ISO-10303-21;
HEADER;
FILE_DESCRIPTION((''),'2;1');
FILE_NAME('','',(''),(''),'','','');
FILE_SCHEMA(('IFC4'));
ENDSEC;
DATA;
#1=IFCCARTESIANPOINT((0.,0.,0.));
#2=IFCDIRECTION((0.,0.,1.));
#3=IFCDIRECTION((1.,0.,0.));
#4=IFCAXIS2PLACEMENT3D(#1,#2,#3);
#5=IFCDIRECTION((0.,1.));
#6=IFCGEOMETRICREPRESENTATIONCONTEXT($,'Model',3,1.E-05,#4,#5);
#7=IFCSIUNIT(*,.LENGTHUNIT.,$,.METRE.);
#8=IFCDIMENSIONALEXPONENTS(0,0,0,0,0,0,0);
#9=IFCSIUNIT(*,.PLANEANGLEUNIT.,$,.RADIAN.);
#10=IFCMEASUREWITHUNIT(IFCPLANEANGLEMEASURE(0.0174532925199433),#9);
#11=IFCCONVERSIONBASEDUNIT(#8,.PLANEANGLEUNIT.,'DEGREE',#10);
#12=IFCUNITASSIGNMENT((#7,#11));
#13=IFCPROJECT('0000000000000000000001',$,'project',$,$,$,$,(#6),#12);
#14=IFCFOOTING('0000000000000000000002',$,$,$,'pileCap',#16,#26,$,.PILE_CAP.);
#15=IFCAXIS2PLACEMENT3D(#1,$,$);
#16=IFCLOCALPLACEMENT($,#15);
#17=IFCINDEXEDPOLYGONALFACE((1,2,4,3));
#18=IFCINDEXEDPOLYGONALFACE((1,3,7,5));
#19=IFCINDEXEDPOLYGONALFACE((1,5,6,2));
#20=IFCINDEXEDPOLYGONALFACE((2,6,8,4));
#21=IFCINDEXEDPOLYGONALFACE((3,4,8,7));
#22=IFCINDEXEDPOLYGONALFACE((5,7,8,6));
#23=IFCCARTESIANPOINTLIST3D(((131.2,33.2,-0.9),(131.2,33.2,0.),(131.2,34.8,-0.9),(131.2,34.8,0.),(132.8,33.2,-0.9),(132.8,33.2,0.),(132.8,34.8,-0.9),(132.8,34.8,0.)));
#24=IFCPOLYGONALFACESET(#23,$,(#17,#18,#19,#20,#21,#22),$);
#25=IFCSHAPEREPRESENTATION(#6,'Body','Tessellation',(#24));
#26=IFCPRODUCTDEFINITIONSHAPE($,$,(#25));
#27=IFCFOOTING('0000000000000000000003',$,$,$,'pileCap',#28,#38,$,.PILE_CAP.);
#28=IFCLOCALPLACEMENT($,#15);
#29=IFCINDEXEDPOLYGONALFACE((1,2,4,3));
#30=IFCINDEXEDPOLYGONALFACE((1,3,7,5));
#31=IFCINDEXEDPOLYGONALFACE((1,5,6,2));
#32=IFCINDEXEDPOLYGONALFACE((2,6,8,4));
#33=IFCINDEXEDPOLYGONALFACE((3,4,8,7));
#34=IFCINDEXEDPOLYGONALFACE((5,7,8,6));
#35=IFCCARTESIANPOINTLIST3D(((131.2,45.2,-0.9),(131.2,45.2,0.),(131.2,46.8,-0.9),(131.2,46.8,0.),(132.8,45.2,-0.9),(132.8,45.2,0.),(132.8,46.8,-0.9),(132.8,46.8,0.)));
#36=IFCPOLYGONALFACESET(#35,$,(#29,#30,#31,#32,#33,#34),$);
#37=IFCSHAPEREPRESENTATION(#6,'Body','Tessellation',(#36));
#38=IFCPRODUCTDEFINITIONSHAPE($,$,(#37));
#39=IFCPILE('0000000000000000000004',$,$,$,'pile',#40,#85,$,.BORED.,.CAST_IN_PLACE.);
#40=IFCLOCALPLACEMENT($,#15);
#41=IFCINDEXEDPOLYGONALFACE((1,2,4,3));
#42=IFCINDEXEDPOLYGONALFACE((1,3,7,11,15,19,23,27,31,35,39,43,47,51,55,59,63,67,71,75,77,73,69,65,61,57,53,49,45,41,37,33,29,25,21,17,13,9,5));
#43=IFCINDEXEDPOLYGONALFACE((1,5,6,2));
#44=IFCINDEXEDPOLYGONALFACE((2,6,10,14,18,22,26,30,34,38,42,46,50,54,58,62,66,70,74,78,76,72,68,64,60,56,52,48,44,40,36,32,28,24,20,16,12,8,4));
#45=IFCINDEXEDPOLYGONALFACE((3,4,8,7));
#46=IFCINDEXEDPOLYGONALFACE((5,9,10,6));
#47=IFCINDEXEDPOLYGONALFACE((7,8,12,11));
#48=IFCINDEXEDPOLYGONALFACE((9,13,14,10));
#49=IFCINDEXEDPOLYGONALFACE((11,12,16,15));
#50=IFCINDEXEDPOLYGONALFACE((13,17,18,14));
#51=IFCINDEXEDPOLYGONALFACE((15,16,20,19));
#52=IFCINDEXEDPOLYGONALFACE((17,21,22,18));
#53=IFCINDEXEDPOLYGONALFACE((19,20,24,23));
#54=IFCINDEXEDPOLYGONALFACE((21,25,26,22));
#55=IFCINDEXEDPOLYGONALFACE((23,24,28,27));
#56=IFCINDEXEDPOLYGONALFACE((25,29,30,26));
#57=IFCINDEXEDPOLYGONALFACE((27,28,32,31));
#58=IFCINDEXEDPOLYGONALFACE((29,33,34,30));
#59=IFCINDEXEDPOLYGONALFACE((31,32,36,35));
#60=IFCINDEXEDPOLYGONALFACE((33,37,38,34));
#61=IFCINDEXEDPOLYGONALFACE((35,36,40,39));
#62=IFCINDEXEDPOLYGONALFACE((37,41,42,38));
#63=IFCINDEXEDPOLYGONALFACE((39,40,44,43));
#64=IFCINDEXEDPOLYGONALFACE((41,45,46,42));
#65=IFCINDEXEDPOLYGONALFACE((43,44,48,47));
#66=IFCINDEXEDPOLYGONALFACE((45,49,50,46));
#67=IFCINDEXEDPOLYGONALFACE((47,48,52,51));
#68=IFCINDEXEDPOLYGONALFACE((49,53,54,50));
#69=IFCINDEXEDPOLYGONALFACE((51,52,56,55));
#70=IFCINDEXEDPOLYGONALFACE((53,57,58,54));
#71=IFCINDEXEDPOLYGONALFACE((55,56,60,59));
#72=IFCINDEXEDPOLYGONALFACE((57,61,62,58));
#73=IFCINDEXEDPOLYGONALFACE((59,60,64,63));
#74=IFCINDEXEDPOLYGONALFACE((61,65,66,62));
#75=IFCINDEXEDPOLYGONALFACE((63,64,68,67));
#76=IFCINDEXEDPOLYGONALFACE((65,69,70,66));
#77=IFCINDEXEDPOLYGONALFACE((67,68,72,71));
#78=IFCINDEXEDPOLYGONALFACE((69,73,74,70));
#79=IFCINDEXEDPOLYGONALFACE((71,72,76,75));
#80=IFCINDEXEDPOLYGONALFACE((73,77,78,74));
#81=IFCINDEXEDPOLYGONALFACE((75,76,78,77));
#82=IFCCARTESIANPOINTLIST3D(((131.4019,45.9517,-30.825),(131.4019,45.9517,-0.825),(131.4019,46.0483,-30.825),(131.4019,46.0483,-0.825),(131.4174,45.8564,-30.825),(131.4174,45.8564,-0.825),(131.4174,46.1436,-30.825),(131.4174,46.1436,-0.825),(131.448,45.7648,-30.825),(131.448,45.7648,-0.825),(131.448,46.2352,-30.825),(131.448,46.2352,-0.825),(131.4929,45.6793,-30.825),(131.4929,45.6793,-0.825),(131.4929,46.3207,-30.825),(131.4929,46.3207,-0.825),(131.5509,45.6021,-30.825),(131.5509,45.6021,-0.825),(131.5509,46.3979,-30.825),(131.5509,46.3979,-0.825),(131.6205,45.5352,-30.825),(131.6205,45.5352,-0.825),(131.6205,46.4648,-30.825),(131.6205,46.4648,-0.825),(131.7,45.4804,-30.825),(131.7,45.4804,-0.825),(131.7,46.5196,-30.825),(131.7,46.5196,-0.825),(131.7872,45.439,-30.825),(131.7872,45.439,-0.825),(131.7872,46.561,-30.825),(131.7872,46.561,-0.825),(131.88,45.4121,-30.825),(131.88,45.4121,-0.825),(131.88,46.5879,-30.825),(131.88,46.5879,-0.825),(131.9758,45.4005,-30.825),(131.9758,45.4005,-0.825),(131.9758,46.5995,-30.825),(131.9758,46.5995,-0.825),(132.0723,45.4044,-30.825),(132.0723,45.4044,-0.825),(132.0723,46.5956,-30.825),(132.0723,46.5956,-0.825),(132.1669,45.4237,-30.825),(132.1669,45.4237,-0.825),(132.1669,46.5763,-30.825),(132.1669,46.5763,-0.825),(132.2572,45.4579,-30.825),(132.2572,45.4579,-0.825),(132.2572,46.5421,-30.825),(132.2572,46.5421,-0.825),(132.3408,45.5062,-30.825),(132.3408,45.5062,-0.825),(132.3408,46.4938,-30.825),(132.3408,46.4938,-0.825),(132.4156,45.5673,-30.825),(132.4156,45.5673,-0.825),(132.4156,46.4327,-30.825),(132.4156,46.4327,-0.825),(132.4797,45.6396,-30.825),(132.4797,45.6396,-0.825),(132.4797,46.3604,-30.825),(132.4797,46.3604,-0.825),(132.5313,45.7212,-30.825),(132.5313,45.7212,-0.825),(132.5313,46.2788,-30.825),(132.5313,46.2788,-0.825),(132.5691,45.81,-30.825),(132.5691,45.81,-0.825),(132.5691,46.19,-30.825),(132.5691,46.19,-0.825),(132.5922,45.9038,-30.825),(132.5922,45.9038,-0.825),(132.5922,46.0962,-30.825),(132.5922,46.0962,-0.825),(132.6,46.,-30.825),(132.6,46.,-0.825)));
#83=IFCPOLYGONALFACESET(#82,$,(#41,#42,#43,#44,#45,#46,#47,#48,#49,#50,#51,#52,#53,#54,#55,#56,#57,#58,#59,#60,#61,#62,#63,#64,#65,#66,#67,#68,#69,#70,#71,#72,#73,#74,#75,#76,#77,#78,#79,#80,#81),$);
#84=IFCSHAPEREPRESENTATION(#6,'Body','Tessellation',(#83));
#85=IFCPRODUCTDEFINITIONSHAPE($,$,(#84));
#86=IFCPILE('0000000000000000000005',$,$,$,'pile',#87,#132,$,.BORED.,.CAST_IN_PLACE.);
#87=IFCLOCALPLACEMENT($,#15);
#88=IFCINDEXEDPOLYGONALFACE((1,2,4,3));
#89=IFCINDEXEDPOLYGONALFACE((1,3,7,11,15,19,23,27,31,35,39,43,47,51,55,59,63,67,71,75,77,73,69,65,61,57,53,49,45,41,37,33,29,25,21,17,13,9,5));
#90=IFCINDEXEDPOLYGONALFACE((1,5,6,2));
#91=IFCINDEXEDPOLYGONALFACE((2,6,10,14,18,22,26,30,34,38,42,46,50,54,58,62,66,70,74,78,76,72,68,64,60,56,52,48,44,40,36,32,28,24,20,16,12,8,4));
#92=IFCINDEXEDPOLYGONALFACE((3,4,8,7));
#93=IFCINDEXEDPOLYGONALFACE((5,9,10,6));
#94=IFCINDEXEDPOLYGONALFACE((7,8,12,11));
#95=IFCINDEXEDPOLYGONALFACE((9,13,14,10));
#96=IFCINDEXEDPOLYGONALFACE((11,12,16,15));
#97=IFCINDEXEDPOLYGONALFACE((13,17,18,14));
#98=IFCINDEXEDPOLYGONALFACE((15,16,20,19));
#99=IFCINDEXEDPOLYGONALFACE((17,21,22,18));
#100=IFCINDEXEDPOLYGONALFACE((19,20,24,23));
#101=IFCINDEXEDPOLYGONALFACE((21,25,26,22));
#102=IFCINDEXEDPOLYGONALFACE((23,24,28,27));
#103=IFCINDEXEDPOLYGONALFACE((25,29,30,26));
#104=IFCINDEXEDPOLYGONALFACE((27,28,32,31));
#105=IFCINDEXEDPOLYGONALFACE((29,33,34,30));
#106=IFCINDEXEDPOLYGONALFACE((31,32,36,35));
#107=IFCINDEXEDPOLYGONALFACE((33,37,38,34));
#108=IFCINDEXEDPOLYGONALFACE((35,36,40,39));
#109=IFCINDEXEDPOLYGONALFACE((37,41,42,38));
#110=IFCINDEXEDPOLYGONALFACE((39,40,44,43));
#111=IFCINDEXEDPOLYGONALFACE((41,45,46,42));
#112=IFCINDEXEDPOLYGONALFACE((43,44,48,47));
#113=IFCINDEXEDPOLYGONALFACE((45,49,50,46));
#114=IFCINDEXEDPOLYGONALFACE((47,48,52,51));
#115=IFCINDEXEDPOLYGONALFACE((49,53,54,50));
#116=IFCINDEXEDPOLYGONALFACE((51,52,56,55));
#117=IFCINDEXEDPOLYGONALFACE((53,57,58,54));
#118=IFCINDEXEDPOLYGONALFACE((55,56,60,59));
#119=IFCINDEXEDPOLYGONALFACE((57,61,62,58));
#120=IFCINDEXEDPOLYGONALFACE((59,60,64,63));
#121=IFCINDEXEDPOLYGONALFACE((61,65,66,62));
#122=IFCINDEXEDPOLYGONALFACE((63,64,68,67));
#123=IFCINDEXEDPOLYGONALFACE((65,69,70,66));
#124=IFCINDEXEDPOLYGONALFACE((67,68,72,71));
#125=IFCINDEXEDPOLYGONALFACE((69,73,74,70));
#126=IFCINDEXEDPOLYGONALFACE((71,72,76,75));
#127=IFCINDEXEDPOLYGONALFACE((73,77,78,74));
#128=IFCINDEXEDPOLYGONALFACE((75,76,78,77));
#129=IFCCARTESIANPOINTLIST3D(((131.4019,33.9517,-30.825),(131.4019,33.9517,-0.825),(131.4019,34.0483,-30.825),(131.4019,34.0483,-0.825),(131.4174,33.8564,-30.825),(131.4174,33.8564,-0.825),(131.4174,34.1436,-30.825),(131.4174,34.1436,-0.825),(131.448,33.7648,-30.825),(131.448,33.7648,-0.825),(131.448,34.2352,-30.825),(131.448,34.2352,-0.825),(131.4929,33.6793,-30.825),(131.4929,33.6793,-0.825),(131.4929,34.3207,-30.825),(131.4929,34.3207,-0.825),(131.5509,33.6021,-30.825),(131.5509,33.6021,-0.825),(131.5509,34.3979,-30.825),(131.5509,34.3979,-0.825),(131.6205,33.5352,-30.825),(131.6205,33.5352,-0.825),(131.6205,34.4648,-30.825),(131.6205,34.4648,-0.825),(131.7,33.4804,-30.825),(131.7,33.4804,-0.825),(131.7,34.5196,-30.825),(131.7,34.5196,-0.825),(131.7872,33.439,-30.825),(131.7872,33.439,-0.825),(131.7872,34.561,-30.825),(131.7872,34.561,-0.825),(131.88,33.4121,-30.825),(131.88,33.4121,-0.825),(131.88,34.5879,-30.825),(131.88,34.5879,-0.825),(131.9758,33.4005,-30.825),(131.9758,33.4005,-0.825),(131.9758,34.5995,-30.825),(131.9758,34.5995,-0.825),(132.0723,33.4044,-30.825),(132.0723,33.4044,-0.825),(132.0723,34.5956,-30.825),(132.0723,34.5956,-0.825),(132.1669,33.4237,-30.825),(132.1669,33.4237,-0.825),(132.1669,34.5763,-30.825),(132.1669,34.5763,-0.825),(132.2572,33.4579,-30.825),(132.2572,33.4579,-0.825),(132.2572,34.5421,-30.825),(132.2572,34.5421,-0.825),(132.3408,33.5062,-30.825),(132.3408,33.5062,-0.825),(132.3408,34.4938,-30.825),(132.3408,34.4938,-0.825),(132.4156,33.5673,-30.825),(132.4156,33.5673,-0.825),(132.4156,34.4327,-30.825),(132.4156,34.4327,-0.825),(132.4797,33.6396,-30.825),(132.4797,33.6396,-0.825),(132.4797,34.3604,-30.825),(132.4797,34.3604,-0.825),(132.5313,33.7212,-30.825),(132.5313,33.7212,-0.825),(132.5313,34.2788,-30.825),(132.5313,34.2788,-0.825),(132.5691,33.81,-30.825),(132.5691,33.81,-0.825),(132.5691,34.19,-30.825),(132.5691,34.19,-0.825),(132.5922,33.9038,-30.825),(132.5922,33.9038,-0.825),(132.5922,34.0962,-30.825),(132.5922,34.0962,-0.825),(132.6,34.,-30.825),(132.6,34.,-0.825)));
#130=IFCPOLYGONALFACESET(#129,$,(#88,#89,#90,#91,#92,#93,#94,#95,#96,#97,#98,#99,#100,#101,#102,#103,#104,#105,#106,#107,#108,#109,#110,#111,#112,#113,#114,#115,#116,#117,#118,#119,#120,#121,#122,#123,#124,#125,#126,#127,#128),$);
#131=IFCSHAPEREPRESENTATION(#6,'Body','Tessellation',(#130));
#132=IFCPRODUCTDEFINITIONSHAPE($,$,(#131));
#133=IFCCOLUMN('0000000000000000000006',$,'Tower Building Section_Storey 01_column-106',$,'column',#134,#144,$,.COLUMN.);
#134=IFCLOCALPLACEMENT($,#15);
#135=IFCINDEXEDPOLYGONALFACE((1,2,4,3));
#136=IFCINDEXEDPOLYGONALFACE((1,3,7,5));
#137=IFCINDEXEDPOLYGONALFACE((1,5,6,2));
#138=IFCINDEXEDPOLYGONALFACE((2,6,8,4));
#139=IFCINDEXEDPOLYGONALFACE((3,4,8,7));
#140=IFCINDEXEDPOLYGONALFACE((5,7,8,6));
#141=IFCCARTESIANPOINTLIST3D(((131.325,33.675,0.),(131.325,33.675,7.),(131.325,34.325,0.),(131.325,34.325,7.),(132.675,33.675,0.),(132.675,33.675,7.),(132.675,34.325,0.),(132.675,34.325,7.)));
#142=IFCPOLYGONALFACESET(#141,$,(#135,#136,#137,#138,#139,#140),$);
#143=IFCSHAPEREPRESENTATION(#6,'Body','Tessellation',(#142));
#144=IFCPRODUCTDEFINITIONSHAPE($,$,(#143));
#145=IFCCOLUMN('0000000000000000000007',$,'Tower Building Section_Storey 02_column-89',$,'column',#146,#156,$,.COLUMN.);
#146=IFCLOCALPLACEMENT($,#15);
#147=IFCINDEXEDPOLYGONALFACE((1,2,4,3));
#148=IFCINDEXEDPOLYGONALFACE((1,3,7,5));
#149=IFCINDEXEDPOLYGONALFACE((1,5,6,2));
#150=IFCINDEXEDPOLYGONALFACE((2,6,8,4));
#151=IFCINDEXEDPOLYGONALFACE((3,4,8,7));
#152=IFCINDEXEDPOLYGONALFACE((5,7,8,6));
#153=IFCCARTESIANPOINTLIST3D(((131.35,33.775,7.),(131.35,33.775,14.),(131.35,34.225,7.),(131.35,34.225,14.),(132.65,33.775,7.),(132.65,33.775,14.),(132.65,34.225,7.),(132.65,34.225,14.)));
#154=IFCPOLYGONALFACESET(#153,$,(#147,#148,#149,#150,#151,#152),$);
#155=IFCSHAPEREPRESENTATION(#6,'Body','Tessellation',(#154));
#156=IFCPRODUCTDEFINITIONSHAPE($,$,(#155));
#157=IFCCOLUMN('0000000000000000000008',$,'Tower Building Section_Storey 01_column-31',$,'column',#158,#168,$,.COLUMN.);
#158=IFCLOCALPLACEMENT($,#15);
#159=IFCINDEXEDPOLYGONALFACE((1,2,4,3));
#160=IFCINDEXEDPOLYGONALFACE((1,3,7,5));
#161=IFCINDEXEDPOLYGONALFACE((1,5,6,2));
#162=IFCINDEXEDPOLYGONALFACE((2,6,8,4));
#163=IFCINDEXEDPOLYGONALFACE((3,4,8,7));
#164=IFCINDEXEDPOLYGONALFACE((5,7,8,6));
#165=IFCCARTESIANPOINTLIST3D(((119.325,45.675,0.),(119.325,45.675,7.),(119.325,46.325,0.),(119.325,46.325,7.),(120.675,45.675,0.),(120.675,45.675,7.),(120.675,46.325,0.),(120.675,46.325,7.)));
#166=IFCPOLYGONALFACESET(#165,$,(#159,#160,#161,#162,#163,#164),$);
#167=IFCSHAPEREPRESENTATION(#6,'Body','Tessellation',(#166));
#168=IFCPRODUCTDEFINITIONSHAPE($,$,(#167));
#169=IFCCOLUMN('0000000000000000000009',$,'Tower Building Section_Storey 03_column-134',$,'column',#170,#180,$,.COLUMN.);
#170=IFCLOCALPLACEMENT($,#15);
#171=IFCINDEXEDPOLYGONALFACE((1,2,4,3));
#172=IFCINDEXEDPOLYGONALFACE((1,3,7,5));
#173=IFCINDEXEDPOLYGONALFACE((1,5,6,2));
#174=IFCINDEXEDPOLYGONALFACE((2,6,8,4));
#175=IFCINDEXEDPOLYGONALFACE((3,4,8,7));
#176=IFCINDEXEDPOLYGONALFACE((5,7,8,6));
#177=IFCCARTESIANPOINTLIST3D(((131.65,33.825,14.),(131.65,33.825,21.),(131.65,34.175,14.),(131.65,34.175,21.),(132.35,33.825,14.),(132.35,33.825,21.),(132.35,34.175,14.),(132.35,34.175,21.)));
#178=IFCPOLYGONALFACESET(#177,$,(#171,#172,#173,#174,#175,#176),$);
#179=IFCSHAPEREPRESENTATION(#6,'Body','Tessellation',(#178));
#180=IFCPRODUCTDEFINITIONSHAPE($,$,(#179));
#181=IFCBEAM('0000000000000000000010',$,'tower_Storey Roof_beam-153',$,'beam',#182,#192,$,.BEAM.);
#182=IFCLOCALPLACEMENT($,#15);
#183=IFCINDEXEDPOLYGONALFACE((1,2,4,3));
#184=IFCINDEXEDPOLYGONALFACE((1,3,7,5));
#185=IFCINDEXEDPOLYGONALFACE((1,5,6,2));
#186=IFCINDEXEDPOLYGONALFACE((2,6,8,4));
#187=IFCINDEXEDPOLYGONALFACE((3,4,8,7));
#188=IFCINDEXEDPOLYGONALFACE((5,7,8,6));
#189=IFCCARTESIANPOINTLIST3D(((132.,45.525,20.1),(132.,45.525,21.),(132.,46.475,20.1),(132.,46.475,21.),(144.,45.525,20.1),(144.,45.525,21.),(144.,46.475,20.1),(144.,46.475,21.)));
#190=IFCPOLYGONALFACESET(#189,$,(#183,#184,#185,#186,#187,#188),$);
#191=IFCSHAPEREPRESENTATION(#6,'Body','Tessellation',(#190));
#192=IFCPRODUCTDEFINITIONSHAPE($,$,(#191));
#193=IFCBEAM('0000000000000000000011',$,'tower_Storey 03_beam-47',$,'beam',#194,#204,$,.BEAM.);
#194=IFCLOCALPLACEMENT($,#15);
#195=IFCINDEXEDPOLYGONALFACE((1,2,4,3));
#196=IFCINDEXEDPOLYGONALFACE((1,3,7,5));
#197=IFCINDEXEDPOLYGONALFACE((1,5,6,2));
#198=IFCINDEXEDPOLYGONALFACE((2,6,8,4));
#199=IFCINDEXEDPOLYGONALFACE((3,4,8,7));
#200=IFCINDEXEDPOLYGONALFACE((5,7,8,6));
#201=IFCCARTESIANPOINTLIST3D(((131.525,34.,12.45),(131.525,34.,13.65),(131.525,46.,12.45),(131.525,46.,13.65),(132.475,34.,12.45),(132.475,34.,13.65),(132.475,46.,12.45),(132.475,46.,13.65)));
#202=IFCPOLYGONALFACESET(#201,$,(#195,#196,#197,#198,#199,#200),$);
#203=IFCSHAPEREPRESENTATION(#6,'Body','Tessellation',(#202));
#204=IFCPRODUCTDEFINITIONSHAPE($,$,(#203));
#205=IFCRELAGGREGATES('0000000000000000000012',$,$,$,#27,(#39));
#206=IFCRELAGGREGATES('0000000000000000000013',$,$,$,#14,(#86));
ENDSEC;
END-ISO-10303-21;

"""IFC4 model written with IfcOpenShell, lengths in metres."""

from ifc_helpers import new_model, entity, si_unit, converted_unit, direction, frame, origin_with_axes, place, context, project, polyline, circle_curve, parameter, trimmed, segment, composite_curve, outline, extrude, element, aggregate, save


model = new_model("IFC4")

# Units and contexts
model_context = context("Model", 3, precision=1e-05, world=origin_with_axes(), true_north=direction((0.0, 1.0)))
ifc_project = project(units=[si_unit("LENGTHUNIT", "METRE"), converted_unit("PLANEANGLEUNIT", "DEGREE", entity("IfcPlaneAngleMeasure", 0.0174532925199433), si_unit("PLANEANGLEUNIT", "RADIAN"), dimensions=[0, 0, 0, 0, 0, 0, 0])], contexts=[model_context])

# Footing
placement_1 = place(None, origin_with_axes())
placement_2 = place(placement_1, origin_with_axes())
footing_1_placement = place(placement_2, frame((132.0, 34.0, -0.9), z_axis=(0.0, 0.0, 1.0), x_axis=(1.0, 0.0, 0.0)))
footing_1 = element("IfcFooting", 1, at=footing_1_placement, ObjectType="pileCap", PredefinedType="PILE_CAP", context=model_context, body=[
    extrude(outline(polyline([(0.8, -0.8, 0.0), (0.8, 0.8, 0.0), (-0.8, 0.8, 0.0), (-0.8, -0.8, 0.0), (0.8, -0.8, 0.0)])), origin_with_axes(), (0.0, 0.0, 1.0), 0.9),
])

# Footing, pile
footing_2_placement = place(placement_2, frame((132.0, 46.0, -0.9), z_axis=(0.0, 0.0, 1.0), x_axis=(1.0, 0.0, 0.0)))
footing_2 = element("IfcFooting", 2, at=footing_2_placement, ObjectType="pileCap", PredefinedType="PILE_CAP", context=model_context, body=[
    extrude(outline(polyline([(0.8, -0.8, 0.0), (0.8, 0.8, 0.0), (-0.8, 0.8, 0.0), (-0.8, -0.8, 0.0), (0.8, -0.8, 0.0)])), origin_with_axes(), (0.0, 0.0, 1.0), 0.9),
])
pile_1_placement = place(footing_2_placement, frame((0.0, 0.0, -29.925), z_axis=(0.0, 0.0, 1.0), x_axis=(1.0, 0.0, 0.0)))
pile_1 = element("IfcPile", 3, at=pile_1_placement, ObjectType="pile", ConstructionType="CAST_IN_PLACE", PredefinedType="BORED", context=model_context, body=[
    extrude(outline(composite_curve([segment(trimmed(circle_curve(origin_with_axes(), 0.6), [parameter(0.0)], [parameter(360.0)], True, "PARAMETER"), True, "CONTINUOUS")], self_intersect=False)), origin_with_axes(), (0.0, 0.0, 1.0), 30.0),
])
aggregate(footing_2, [pile_1])

# Pile
pile_2_placement = place(footing_1_placement, frame((0.0, 0.0, -29.925), z_axis=(0.0, 0.0, 1.0), x_axis=(1.0, 0.0, 0.0)))
pile_2 = element("IfcPile", 4, at=pile_2_placement, ObjectType="pile", ConstructionType="CAST_IN_PLACE", PredefinedType="BORED", context=model_context, body=[
    extrude(outline(composite_curve([segment(trimmed(circle_curve(origin_with_axes(), 0.6), [parameter(0.0)], [parameter(360.0)], True, "PARAMETER"), True, "CONTINUOUS")], self_intersect=False)), origin_with_axes(), (0.0, 0.0, 1.0), 30.0),
])
aggregate(footing_1, [pile_2])

# Columns
column_1_placement = place(placement_2, frame((132.0, 34.0, 0.0), z_axis=(0.0, 0.0, 1.0), x_axis=(1.0, 0.0, 0.0)))
element("IfcColumn", 5, at=column_1_placement, Name="Tower Building Section_Storey 01_column-106", ObjectType="column", PredefinedType="COLUMN", context=model_context, body=[
    extrude(outline(polyline([(-0.675, -0.325, 0.0), (0.675, -0.325, 0.0), (0.675, 0.325, 0.0), (-0.675, 0.325, 0.0), (-0.675, -0.325, 0.0)])), origin_with_axes(), (0.0, 0.0, 1.0), 7.0),
])
placement_3 = place(placement_1, frame((0.0, 0.0, 7.0), z_axis=(0.0, 0.0, 1.0), x_axis=(1.0, 0.0, 0.0)))
column_2_placement = place(placement_3, frame((132.0, 34.0, 0.0), z_axis=(0.0, 0.0, 1.0), x_axis=(1.0, 0.0, 0.0)))
element("IfcColumn", 6, at=column_2_placement, Name="Tower Building Section_Storey 02_column-89", ObjectType="column", PredefinedType="COLUMN", context=model_context, body=[
    extrude(outline(polyline([(-0.65, -0.225, 0.0), (0.65, -0.225, 0.0), (0.65, 0.225, 0.0), (-0.65, 0.225, 0.0), (-0.65, -0.225, 0.0)])), origin_with_axes(), (0.0, 0.0, 1.0), 7.0),
])
column_3_placement = place(placement_2, frame((120.0, 46.0, 0.0), z_axis=(0.0, 0.0, 1.0), x_axis=(1.0, 0.0, 0.0)))
element("IfcColumn", 7, at=column_3_placement, Name="Tower Building Section_Storey 01_column-31", ObjectType="column", PredefinedType="COLUMN", context=model_context, body=[
    extrude(outline(polyline([(-0.675, -0.325, 0.0), (0.675, -0.325, 0.0), (0.675, 0.325, 0.0), (-0.675, 0.325, 0.0), (-0.675, -0.325, 0.0)])), origin_with_axes(), (0.0, 0.0, 1.0), 7.0),
])
placement_4 = place(placement_1, frame((0.0, 0.0, 14.0), z_axis=(0.0, 0.0, 1.0), x_axis=(1.0, 0.0, 0.0)))
column_4_placement = place(placement_4, frame((132.0, 34.0, 0.0), z_axis=(0.0, 0.0, 1.0), x_axis=(1.0, 0.0, 0.0)))
element("IfcColumn", 8, at=column_4_placement, Name="Tower Building Section_Storey 03_column-134", ObjectType="column", PredefinedType="COLUMN", context=model_context, body=[
    extrude(outline(polyline([(-0.35, -0.175, 0.0), (0.35, -0.175, 0.0), (0.35, 0.175, 0.0), (-0.35, 0.175, 0.0), (-0.35, -0.175, 0.0)])), origin_with_axes(), (0.0, 0.0, 1.0), 7.0),
])

# Beams
placement_5 = place(placement_1, frame((0.0, 0.0, 21.0), z_axis=(0.0, 0.0, 1.0), x_axis=(1.0, 0.0, 0.0)))
beam_1_placement = place(placement_5, frame((132.0, 46.0, -0.45), z_axis=(1.0, 0.0, 0.0), x_axis=(0.0, 1.0, 0.0)))
element("IfcBeam", 9, at=beam_1_placement, Name="tower_Storey Roof_beam-153", ObjectType="beam", PredefinedType="BEAM", context=model_context, body=[
    extrude(outline(polyline([(0.475, 0.45, 0.0), (-0.475, 0.45, 0.0), (-0.475, -0.45, 0.0), (0.475, -0.45, 0.0), (0.475, 0.45, 0.0)])), origin_with_axes(), (0.0, 0.0, 1.0), 12.0),
])
beam_2_placement = place(placement_4, frame((132.0, 34.0, -0.95), z_axis=(0.0, 1.0, 0.0), x_axis=(-1.0, 0.0, 0.0)))
element("IfcBeam", 10, at=beam_2_placement, Name="tower_Storey 03_beam-47", ObjectType="beam", PredefinedType="BEAM", context=model_context, body=[
    extrude(outline(polyline([(0.475, 0.6, 0.0), (-0.475, 0.6, 0.0), (-0.475, -0.6, 0.0), (0.475, -0.6, 0.0), (0.475, 0.6, 0.0)])), origin_with_axes(), (0.0, 0.0, 1.0), 12.0),
])

save(model, "model.ifc")
